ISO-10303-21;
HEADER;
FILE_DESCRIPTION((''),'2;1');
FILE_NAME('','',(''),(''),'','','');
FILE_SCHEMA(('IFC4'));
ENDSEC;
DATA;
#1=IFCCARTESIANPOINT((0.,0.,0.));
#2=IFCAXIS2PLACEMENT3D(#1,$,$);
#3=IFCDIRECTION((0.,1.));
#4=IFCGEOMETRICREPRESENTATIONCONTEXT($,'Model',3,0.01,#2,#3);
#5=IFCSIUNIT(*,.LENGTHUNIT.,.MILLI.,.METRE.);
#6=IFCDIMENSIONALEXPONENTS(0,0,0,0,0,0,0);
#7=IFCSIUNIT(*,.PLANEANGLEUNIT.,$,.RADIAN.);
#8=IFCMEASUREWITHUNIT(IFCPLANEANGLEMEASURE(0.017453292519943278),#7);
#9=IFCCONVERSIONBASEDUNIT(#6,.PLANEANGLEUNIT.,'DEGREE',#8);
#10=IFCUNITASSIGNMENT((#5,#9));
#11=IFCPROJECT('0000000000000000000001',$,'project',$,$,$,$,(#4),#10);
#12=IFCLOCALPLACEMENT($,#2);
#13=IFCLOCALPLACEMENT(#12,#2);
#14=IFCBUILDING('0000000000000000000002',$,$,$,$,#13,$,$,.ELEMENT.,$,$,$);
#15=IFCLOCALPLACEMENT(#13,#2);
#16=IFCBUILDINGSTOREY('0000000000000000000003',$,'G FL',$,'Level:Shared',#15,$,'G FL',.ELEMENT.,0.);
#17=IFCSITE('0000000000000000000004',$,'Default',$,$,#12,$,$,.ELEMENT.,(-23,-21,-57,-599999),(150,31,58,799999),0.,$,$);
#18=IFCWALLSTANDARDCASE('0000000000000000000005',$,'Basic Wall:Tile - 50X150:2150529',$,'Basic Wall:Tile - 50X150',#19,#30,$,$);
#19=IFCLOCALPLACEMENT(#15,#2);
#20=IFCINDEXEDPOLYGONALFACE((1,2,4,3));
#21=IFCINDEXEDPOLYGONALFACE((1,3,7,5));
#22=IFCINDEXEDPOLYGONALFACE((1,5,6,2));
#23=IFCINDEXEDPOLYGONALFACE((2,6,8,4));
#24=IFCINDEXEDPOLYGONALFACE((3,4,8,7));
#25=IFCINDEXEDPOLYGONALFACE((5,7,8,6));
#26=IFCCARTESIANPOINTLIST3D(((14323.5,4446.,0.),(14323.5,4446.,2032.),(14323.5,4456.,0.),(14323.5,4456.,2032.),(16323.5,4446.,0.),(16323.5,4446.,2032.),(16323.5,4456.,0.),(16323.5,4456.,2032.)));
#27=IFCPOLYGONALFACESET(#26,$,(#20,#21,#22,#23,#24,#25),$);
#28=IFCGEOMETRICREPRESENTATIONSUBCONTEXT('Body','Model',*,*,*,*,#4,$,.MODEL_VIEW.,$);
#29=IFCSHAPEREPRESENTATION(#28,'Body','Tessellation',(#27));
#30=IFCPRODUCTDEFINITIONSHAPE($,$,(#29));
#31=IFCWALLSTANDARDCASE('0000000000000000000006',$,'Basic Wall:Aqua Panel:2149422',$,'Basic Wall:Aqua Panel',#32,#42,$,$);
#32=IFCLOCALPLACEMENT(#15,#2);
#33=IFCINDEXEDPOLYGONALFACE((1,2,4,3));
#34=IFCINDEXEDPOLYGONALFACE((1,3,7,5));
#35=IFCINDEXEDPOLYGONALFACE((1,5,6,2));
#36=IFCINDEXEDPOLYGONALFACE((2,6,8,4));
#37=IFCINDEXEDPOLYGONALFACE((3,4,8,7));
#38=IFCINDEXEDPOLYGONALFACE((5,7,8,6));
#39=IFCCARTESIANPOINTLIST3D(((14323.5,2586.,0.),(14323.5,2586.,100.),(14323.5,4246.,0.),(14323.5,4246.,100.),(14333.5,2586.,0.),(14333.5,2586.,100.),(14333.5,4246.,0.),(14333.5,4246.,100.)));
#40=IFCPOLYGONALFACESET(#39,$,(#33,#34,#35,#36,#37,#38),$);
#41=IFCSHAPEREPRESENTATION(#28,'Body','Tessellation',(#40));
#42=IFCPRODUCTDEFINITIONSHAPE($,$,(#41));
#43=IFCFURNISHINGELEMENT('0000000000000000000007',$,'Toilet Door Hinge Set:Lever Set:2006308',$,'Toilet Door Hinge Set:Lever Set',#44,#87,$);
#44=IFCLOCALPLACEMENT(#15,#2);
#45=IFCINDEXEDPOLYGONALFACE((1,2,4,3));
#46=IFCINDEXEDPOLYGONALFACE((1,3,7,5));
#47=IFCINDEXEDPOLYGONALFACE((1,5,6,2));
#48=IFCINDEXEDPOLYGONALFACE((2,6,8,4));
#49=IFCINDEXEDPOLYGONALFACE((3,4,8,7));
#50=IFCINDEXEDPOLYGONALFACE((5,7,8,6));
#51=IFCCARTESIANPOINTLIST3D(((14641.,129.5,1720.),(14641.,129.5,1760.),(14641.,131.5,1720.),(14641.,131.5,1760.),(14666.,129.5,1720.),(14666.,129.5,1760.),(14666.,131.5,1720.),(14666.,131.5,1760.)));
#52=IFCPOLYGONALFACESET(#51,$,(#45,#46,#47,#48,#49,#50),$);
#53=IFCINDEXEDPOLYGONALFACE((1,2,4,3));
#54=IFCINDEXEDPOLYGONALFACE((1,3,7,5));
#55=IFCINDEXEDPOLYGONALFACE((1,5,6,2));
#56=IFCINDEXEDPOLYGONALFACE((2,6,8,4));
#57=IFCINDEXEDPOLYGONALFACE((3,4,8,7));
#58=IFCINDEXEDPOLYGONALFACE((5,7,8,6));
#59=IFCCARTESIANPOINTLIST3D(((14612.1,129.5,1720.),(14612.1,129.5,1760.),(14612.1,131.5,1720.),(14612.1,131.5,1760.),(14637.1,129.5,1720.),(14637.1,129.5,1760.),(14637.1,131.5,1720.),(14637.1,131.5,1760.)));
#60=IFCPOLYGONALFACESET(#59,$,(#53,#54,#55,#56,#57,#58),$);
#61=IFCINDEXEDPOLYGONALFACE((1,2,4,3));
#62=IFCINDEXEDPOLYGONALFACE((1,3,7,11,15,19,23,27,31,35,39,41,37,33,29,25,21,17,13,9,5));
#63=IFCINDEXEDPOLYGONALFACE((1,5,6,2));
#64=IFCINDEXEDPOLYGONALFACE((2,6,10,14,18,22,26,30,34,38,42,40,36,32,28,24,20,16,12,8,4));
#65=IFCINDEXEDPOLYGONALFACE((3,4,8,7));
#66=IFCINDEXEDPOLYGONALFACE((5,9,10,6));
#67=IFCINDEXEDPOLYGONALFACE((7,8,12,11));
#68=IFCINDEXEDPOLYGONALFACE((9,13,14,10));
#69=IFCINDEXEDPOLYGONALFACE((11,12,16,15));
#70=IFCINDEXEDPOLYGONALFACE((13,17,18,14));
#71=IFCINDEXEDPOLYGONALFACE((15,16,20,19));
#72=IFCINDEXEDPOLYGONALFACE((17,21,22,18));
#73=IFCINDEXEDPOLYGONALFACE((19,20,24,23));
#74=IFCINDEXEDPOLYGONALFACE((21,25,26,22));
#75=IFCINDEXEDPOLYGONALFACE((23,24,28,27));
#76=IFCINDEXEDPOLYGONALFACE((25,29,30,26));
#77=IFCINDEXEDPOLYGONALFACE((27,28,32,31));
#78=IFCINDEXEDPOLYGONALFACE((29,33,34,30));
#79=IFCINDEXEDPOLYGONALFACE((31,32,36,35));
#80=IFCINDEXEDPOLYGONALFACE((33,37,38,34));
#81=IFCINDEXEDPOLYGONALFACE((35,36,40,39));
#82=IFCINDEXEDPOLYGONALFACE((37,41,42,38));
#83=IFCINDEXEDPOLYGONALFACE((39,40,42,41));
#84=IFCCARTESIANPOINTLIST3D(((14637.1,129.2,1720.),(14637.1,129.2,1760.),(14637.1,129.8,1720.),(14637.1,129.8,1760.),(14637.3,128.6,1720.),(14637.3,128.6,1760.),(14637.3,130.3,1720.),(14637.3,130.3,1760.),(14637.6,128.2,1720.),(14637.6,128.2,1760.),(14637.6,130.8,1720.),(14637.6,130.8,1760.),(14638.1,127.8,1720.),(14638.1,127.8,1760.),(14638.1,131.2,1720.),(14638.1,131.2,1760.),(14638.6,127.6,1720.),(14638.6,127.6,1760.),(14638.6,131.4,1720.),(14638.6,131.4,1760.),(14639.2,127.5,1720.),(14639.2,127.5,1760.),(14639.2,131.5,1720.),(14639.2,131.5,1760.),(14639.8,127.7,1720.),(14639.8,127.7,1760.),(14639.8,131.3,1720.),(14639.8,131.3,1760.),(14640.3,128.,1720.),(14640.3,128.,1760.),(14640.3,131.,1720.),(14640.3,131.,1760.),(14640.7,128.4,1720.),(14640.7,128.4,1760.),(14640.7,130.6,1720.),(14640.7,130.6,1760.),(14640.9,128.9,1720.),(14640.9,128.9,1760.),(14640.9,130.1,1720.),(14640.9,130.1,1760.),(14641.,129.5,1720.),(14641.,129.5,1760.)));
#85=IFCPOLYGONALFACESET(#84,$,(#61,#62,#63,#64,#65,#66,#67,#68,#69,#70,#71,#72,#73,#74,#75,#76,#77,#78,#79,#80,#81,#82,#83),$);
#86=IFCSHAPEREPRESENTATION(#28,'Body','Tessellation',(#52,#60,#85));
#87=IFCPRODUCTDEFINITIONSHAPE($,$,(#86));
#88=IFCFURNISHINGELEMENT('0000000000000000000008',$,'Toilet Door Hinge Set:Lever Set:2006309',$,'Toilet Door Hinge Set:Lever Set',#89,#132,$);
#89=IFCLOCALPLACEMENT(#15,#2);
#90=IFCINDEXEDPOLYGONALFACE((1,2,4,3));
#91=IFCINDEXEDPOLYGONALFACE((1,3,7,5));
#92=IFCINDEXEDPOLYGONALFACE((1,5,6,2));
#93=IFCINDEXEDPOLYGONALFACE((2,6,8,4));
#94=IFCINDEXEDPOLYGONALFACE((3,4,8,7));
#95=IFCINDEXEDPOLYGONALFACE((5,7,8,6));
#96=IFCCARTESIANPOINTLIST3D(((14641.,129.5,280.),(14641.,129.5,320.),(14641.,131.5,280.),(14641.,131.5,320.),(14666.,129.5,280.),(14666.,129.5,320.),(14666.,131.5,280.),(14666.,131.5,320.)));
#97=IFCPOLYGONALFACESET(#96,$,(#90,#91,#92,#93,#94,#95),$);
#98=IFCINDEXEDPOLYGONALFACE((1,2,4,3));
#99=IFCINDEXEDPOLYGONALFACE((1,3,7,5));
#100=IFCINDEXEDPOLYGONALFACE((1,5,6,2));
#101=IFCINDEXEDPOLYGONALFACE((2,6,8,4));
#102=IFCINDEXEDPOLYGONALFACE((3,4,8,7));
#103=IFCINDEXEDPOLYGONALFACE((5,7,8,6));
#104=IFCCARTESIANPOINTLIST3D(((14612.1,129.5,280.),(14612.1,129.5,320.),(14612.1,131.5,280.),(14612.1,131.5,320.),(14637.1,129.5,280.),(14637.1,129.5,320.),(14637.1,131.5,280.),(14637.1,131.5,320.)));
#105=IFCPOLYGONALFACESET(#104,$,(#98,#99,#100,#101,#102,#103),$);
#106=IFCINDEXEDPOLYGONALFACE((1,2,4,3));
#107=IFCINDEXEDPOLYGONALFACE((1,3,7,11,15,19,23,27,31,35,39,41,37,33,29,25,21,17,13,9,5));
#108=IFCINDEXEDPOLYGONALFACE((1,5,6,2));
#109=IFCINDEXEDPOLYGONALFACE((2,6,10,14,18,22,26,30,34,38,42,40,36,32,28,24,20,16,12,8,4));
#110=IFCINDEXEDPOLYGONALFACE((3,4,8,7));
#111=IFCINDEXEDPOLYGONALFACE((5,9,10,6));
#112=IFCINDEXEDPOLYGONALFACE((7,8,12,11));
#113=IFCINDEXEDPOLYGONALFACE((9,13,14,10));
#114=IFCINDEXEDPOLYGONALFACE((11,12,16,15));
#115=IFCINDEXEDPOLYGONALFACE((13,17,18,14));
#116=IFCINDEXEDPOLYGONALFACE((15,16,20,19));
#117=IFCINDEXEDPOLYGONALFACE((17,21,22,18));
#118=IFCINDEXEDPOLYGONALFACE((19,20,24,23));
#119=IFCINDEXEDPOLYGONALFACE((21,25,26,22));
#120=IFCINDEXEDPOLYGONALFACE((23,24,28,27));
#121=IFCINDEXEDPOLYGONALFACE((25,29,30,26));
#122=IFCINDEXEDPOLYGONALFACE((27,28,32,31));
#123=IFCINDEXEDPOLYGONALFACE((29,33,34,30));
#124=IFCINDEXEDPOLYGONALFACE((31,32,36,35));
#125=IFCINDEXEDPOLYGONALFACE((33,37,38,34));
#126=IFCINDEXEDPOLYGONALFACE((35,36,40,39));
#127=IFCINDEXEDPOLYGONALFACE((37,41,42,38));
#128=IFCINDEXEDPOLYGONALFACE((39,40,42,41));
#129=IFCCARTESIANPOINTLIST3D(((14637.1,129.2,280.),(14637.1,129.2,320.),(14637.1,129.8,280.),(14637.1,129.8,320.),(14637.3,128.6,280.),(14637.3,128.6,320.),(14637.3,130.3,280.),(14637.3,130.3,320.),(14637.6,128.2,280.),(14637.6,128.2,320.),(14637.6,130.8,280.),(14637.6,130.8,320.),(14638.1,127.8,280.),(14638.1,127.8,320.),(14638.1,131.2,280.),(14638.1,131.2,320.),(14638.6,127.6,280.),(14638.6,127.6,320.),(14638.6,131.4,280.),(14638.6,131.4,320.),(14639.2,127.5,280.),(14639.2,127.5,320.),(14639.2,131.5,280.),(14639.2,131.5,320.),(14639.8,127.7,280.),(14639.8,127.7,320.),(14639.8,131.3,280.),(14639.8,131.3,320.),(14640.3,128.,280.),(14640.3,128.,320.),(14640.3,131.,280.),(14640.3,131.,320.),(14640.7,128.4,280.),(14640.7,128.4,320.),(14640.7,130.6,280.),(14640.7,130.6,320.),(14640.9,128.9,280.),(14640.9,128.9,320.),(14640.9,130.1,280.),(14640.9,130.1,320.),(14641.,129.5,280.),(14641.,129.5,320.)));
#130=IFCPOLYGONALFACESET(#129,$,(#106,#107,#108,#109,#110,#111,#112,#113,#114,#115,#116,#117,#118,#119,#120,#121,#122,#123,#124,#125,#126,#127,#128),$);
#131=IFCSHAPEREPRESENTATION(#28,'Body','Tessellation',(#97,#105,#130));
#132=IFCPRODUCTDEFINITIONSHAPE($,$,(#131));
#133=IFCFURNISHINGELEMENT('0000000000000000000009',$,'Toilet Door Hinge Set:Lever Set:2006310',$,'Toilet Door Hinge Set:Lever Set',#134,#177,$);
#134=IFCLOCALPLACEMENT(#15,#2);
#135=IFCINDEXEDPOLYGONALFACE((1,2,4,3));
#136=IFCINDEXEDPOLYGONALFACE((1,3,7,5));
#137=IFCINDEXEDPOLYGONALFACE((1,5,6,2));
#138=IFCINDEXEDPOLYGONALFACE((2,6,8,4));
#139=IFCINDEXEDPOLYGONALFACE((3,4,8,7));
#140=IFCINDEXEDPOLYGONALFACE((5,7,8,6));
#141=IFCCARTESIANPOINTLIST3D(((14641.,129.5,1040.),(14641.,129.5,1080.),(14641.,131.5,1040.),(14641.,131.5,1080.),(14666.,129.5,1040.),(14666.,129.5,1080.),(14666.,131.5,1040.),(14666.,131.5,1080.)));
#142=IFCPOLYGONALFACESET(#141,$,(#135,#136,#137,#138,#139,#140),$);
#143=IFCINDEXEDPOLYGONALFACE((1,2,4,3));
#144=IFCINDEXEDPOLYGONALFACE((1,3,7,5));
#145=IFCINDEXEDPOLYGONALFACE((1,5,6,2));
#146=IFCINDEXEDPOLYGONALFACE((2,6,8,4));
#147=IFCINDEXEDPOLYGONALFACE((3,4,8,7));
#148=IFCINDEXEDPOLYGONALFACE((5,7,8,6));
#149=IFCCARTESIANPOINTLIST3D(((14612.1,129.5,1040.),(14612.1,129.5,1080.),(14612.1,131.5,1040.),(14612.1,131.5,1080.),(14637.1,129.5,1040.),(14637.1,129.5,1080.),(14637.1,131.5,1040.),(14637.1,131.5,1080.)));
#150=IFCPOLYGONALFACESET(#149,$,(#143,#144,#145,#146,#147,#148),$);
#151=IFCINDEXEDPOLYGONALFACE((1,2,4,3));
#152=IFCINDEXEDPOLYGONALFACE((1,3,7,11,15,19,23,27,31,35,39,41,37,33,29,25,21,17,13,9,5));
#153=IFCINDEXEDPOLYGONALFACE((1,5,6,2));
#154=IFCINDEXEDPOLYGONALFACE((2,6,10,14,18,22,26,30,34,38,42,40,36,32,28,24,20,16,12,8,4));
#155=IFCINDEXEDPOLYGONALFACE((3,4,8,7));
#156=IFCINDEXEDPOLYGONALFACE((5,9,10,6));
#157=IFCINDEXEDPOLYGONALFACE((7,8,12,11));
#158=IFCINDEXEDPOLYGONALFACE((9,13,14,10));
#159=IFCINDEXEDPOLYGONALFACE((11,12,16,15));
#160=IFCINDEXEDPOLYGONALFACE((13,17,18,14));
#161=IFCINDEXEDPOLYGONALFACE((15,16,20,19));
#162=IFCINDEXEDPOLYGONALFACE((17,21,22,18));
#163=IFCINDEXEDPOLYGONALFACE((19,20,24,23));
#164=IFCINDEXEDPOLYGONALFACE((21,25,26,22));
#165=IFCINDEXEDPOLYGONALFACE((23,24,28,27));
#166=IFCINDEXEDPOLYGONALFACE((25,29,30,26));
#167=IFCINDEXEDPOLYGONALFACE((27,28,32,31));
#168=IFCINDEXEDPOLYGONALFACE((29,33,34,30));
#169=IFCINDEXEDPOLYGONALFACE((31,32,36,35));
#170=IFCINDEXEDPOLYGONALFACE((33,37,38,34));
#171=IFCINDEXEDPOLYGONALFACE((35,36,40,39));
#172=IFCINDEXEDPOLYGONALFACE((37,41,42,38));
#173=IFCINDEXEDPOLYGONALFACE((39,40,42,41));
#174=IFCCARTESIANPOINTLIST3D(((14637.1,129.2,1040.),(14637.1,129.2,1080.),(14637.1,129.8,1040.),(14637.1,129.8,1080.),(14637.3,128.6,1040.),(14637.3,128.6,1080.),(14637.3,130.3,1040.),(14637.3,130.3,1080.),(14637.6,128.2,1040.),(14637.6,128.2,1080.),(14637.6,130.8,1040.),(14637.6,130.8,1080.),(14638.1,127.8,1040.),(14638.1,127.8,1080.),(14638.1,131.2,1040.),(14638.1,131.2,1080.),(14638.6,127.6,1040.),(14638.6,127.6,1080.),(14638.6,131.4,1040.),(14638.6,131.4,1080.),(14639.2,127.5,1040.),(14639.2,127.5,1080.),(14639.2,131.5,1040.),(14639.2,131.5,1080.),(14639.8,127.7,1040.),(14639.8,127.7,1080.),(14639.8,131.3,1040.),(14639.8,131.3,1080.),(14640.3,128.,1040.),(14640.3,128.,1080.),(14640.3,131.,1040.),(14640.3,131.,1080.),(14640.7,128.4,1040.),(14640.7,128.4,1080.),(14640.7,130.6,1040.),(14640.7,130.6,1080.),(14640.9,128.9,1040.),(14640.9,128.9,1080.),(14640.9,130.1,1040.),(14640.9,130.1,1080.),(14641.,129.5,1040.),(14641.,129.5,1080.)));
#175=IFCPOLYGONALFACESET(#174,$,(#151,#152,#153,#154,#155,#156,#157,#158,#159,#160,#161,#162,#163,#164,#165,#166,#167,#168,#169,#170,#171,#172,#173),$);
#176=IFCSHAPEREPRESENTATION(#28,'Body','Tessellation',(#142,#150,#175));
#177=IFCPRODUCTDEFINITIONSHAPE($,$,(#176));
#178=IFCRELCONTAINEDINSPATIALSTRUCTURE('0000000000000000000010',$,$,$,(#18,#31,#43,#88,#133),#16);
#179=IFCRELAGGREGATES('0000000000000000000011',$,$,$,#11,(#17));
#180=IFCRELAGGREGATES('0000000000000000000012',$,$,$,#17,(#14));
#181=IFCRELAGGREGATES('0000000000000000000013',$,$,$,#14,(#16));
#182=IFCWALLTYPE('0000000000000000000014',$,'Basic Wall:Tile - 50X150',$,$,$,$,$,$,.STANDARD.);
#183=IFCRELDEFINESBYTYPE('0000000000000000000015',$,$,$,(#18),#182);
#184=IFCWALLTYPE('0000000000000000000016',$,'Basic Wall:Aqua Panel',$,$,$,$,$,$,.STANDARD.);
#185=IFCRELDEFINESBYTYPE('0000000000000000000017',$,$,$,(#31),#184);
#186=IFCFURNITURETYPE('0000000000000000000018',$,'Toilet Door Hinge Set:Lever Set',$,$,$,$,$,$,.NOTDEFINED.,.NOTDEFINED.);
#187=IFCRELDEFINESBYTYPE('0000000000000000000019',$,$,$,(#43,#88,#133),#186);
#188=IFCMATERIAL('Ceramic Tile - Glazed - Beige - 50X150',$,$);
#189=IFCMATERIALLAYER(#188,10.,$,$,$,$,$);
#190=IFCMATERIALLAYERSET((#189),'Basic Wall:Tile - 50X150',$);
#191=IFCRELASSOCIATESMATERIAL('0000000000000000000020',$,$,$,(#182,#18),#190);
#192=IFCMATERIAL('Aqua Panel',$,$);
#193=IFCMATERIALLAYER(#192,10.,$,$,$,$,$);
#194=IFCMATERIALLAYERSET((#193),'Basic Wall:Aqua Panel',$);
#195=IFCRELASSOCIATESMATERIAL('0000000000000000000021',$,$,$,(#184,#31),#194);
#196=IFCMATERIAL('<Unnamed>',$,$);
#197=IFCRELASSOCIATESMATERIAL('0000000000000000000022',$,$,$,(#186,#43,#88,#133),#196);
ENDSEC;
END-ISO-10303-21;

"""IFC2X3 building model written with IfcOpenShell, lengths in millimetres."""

from ifc_helpers import new_model, entity, si_unit, converted_unit, direction, frame, frame_2d, origin, place, context, subcontext, project, spatial, rectangle, circle, extrude, source, transform, mapped, material, layer, layer_set, layer_usage, type_object, type_shapes, element, save


model = new_model("IFC2X3")

# Units and contexts
model_context = context("Model", 3, precision=0.01, world=origin(), true_north=direction((0.0, 1.0)))
body_context = subcontext(model_context, "Body", "Model", "MODEL_VIEW")
ifc_project = project(units=[si_unit("LENGTHUNIT", "METRE", prefix="MILLI"), converted_unit("PLANEANGLEUNIT", "DEGREE", entity("IfcPlaneAngleMeasure", 0.017453292519943278), si_unit("PLANEANGLEUNIT", "RADIAN"), dimensions=[0, 0, 0, 0, 0, 0, 0])], contexts=[model_context])

# Site, building, storey
site_placement = place(None, origin())
site = spatial("IfcSite", under=ifc_project, at=site_placement, Name="Default", CompositionType="ELEMENT", RefLatitude=(-23, -21, -57, -599999), RefLongitude=(150, 31, 58, 799999), RefElevation=0.0)
building_placement = place(site_placement, origin())
building = spatial("IfcBuilding", under=site, at=building_placement, CompositionType="ELEMENT")
storey_placement = place(building_placement, origin())
storey = spatial("IfcBuildingStorey", under=building, at=storey_placement, Name="G FL", ObjectType="Level:Shared", LongName="G FL", CompositionType="ELEMENT", Elevation=0.0)

# Walls
ifc_material_1 = material(Name="Ceramic Tile - Glazed - Beige - 50X150")
ifc_layer_1 = layer(ifc_material_1, 10.0)
ifc_layer_set_1 = layer_set([ifc_layer_1], Name="Basic Wall:Tile - 50X150")
wall_type_1 = type_object("IfcWallType", Name="Basic Wall:Tile - 50X150", PredefinedType="STANDARD", material=ifc_layer_set_1)
ifc_layer_usage_1 = layer_usage(ifc_layer_set_1, "AXIS2", "NEGATIVE", 5.0)
wall_1_placement = place(storey_placement, frame((16323.5, 4451.0, 0.0), z_axis=(0.0, 0.0, 1.0), x_axis=(-1.0, 0.0, 0.0)))
element("IfcWallStandardCase", 1, at=wall_1_placement, inside=storey, type_object=wall_type_1, material=ifc_layer_usage_1, Name="Basic Wall:Tile - 50X150:2150529", ObjectType="Basic Wall:Tile - 50X150", context=body_context, shape_type="SweptSolid", body=[
    extrude(rectangle(XDim=2000.0, YDim=10.0, at=frame_2d((1000.0, 0.0), x_axis=(-1.0, 0.0))), origin(), (0.0, 0.0, 1.0), 2032.0),
])
ifc_material_2 = material(Name="Aqua Panel")
ifc_layer_2 = layer(ifc_material_2, 10.0)
ifc_layer_set_2 = layer_set([ifc_layer_2], Name="Basic Wall:Aqua Panel")
ifc_layer_usage_2 = layer_usage(ifc_layer_set_2, "AXIS2", "NEGATIVE", 5.0)
wall_type_2 = type_object("IfcWallType", Name="Basic Wall:Aqua Panel", PredefinedType="STANDARD", material=ifc_layer_set_2)
wall_2_placement = place(storey_placement, frame((14328.5, 2586.0, 0.0), z_axis=(0.0, 0.0, 1.0), x_axis=(0.0, 1.0, 0.0)))
element("IfcWallStandardCase", 2, at=wall_2_placement, inside=storey, type_object=wall_type_2, material=ifc_layer_usage_2, Name="Basic Wall:Aqua Panel:2149422", ObjectType="Basic Wall:Aqua Panel", context=body_context, shape_type="SweptSolid", body=[
    extrude(rectangle(XDim=1660.0, YDim=10.0, at=frame_2d((830.0, 0.0), x_axis=(-1.0, 0.0))), origin(), (0.0, 0.0, 1.0), 100.0),
])

# Furnishing elements
ifc_material_3 = material(Name="<Unnamed>")
furniture_type_1 = type_object("IfcFurnitureType", Name="Toilet Door Hinge Set:Lever Set", AssemblyPlace="NOTDEFINED", material=ifc_material_3)
shared_shape_1 = source(origin(), body_context, "Body", "SweptSolid", [
    extrude(rectangle(XDim=2.0, YDim=25.0, at=frame_2d((0.0, 0.0), x_axis=(1.0, 0.0))), frame((14.5, 1.0, -20.0), z_axis=(0.0, 0.0, 1.0), x_axis=(0.0, 1.0, 0.0)), (0.0, 0.0, 1.0), 40.0),
    extrude(rectangle(XDim=25.0, YDim=2.0, at=frame_2d((0.0, 0.0), x_axis=(1.0, 0.0))), frame((-14.5, 1.0, -20.0)), (0.0, 0.0, 1.0), 40.0),
    extrude(circle(Radius=2.0, at=frame_2d((0.0, 0.0), x_axis=(1.0, 0.0))), frame((0.0, 0.0, -20.0)), (0.0, 0.0, 1.0), 40.0),
])
type_shapes(furniture_type_1, [shared_shape_1])
for number, where, name in (
    (3, (14639.0, 129.5, 1740.0), "Toilet Door Hinge Set:Lever Set:2006308"),
    (4, (14639.0, 129.5, 300.0), "Toilet Door Hinge Set:Lever Set:2006309"),
    (5, (14639.0, 129.5, 1060.0), "Toilet Door Hinge Set:Lever Set:2006310"),
):
    element("IfcFurnishingElement", number, at=place(storey_placement, frame(where)), inside=storey, type_object=furniture_type_1, material=ifc_material_3, Name=name, ObjectType="Toilet Door Hinge Set:Lever Set", context=body_context, shape_type="MappedRepresentation", body=[
        mapped(shared_shape_1, transform((0.0, 0.0, 0.0), scale=1.0)),
    ])

save(model, "model.ifc")
